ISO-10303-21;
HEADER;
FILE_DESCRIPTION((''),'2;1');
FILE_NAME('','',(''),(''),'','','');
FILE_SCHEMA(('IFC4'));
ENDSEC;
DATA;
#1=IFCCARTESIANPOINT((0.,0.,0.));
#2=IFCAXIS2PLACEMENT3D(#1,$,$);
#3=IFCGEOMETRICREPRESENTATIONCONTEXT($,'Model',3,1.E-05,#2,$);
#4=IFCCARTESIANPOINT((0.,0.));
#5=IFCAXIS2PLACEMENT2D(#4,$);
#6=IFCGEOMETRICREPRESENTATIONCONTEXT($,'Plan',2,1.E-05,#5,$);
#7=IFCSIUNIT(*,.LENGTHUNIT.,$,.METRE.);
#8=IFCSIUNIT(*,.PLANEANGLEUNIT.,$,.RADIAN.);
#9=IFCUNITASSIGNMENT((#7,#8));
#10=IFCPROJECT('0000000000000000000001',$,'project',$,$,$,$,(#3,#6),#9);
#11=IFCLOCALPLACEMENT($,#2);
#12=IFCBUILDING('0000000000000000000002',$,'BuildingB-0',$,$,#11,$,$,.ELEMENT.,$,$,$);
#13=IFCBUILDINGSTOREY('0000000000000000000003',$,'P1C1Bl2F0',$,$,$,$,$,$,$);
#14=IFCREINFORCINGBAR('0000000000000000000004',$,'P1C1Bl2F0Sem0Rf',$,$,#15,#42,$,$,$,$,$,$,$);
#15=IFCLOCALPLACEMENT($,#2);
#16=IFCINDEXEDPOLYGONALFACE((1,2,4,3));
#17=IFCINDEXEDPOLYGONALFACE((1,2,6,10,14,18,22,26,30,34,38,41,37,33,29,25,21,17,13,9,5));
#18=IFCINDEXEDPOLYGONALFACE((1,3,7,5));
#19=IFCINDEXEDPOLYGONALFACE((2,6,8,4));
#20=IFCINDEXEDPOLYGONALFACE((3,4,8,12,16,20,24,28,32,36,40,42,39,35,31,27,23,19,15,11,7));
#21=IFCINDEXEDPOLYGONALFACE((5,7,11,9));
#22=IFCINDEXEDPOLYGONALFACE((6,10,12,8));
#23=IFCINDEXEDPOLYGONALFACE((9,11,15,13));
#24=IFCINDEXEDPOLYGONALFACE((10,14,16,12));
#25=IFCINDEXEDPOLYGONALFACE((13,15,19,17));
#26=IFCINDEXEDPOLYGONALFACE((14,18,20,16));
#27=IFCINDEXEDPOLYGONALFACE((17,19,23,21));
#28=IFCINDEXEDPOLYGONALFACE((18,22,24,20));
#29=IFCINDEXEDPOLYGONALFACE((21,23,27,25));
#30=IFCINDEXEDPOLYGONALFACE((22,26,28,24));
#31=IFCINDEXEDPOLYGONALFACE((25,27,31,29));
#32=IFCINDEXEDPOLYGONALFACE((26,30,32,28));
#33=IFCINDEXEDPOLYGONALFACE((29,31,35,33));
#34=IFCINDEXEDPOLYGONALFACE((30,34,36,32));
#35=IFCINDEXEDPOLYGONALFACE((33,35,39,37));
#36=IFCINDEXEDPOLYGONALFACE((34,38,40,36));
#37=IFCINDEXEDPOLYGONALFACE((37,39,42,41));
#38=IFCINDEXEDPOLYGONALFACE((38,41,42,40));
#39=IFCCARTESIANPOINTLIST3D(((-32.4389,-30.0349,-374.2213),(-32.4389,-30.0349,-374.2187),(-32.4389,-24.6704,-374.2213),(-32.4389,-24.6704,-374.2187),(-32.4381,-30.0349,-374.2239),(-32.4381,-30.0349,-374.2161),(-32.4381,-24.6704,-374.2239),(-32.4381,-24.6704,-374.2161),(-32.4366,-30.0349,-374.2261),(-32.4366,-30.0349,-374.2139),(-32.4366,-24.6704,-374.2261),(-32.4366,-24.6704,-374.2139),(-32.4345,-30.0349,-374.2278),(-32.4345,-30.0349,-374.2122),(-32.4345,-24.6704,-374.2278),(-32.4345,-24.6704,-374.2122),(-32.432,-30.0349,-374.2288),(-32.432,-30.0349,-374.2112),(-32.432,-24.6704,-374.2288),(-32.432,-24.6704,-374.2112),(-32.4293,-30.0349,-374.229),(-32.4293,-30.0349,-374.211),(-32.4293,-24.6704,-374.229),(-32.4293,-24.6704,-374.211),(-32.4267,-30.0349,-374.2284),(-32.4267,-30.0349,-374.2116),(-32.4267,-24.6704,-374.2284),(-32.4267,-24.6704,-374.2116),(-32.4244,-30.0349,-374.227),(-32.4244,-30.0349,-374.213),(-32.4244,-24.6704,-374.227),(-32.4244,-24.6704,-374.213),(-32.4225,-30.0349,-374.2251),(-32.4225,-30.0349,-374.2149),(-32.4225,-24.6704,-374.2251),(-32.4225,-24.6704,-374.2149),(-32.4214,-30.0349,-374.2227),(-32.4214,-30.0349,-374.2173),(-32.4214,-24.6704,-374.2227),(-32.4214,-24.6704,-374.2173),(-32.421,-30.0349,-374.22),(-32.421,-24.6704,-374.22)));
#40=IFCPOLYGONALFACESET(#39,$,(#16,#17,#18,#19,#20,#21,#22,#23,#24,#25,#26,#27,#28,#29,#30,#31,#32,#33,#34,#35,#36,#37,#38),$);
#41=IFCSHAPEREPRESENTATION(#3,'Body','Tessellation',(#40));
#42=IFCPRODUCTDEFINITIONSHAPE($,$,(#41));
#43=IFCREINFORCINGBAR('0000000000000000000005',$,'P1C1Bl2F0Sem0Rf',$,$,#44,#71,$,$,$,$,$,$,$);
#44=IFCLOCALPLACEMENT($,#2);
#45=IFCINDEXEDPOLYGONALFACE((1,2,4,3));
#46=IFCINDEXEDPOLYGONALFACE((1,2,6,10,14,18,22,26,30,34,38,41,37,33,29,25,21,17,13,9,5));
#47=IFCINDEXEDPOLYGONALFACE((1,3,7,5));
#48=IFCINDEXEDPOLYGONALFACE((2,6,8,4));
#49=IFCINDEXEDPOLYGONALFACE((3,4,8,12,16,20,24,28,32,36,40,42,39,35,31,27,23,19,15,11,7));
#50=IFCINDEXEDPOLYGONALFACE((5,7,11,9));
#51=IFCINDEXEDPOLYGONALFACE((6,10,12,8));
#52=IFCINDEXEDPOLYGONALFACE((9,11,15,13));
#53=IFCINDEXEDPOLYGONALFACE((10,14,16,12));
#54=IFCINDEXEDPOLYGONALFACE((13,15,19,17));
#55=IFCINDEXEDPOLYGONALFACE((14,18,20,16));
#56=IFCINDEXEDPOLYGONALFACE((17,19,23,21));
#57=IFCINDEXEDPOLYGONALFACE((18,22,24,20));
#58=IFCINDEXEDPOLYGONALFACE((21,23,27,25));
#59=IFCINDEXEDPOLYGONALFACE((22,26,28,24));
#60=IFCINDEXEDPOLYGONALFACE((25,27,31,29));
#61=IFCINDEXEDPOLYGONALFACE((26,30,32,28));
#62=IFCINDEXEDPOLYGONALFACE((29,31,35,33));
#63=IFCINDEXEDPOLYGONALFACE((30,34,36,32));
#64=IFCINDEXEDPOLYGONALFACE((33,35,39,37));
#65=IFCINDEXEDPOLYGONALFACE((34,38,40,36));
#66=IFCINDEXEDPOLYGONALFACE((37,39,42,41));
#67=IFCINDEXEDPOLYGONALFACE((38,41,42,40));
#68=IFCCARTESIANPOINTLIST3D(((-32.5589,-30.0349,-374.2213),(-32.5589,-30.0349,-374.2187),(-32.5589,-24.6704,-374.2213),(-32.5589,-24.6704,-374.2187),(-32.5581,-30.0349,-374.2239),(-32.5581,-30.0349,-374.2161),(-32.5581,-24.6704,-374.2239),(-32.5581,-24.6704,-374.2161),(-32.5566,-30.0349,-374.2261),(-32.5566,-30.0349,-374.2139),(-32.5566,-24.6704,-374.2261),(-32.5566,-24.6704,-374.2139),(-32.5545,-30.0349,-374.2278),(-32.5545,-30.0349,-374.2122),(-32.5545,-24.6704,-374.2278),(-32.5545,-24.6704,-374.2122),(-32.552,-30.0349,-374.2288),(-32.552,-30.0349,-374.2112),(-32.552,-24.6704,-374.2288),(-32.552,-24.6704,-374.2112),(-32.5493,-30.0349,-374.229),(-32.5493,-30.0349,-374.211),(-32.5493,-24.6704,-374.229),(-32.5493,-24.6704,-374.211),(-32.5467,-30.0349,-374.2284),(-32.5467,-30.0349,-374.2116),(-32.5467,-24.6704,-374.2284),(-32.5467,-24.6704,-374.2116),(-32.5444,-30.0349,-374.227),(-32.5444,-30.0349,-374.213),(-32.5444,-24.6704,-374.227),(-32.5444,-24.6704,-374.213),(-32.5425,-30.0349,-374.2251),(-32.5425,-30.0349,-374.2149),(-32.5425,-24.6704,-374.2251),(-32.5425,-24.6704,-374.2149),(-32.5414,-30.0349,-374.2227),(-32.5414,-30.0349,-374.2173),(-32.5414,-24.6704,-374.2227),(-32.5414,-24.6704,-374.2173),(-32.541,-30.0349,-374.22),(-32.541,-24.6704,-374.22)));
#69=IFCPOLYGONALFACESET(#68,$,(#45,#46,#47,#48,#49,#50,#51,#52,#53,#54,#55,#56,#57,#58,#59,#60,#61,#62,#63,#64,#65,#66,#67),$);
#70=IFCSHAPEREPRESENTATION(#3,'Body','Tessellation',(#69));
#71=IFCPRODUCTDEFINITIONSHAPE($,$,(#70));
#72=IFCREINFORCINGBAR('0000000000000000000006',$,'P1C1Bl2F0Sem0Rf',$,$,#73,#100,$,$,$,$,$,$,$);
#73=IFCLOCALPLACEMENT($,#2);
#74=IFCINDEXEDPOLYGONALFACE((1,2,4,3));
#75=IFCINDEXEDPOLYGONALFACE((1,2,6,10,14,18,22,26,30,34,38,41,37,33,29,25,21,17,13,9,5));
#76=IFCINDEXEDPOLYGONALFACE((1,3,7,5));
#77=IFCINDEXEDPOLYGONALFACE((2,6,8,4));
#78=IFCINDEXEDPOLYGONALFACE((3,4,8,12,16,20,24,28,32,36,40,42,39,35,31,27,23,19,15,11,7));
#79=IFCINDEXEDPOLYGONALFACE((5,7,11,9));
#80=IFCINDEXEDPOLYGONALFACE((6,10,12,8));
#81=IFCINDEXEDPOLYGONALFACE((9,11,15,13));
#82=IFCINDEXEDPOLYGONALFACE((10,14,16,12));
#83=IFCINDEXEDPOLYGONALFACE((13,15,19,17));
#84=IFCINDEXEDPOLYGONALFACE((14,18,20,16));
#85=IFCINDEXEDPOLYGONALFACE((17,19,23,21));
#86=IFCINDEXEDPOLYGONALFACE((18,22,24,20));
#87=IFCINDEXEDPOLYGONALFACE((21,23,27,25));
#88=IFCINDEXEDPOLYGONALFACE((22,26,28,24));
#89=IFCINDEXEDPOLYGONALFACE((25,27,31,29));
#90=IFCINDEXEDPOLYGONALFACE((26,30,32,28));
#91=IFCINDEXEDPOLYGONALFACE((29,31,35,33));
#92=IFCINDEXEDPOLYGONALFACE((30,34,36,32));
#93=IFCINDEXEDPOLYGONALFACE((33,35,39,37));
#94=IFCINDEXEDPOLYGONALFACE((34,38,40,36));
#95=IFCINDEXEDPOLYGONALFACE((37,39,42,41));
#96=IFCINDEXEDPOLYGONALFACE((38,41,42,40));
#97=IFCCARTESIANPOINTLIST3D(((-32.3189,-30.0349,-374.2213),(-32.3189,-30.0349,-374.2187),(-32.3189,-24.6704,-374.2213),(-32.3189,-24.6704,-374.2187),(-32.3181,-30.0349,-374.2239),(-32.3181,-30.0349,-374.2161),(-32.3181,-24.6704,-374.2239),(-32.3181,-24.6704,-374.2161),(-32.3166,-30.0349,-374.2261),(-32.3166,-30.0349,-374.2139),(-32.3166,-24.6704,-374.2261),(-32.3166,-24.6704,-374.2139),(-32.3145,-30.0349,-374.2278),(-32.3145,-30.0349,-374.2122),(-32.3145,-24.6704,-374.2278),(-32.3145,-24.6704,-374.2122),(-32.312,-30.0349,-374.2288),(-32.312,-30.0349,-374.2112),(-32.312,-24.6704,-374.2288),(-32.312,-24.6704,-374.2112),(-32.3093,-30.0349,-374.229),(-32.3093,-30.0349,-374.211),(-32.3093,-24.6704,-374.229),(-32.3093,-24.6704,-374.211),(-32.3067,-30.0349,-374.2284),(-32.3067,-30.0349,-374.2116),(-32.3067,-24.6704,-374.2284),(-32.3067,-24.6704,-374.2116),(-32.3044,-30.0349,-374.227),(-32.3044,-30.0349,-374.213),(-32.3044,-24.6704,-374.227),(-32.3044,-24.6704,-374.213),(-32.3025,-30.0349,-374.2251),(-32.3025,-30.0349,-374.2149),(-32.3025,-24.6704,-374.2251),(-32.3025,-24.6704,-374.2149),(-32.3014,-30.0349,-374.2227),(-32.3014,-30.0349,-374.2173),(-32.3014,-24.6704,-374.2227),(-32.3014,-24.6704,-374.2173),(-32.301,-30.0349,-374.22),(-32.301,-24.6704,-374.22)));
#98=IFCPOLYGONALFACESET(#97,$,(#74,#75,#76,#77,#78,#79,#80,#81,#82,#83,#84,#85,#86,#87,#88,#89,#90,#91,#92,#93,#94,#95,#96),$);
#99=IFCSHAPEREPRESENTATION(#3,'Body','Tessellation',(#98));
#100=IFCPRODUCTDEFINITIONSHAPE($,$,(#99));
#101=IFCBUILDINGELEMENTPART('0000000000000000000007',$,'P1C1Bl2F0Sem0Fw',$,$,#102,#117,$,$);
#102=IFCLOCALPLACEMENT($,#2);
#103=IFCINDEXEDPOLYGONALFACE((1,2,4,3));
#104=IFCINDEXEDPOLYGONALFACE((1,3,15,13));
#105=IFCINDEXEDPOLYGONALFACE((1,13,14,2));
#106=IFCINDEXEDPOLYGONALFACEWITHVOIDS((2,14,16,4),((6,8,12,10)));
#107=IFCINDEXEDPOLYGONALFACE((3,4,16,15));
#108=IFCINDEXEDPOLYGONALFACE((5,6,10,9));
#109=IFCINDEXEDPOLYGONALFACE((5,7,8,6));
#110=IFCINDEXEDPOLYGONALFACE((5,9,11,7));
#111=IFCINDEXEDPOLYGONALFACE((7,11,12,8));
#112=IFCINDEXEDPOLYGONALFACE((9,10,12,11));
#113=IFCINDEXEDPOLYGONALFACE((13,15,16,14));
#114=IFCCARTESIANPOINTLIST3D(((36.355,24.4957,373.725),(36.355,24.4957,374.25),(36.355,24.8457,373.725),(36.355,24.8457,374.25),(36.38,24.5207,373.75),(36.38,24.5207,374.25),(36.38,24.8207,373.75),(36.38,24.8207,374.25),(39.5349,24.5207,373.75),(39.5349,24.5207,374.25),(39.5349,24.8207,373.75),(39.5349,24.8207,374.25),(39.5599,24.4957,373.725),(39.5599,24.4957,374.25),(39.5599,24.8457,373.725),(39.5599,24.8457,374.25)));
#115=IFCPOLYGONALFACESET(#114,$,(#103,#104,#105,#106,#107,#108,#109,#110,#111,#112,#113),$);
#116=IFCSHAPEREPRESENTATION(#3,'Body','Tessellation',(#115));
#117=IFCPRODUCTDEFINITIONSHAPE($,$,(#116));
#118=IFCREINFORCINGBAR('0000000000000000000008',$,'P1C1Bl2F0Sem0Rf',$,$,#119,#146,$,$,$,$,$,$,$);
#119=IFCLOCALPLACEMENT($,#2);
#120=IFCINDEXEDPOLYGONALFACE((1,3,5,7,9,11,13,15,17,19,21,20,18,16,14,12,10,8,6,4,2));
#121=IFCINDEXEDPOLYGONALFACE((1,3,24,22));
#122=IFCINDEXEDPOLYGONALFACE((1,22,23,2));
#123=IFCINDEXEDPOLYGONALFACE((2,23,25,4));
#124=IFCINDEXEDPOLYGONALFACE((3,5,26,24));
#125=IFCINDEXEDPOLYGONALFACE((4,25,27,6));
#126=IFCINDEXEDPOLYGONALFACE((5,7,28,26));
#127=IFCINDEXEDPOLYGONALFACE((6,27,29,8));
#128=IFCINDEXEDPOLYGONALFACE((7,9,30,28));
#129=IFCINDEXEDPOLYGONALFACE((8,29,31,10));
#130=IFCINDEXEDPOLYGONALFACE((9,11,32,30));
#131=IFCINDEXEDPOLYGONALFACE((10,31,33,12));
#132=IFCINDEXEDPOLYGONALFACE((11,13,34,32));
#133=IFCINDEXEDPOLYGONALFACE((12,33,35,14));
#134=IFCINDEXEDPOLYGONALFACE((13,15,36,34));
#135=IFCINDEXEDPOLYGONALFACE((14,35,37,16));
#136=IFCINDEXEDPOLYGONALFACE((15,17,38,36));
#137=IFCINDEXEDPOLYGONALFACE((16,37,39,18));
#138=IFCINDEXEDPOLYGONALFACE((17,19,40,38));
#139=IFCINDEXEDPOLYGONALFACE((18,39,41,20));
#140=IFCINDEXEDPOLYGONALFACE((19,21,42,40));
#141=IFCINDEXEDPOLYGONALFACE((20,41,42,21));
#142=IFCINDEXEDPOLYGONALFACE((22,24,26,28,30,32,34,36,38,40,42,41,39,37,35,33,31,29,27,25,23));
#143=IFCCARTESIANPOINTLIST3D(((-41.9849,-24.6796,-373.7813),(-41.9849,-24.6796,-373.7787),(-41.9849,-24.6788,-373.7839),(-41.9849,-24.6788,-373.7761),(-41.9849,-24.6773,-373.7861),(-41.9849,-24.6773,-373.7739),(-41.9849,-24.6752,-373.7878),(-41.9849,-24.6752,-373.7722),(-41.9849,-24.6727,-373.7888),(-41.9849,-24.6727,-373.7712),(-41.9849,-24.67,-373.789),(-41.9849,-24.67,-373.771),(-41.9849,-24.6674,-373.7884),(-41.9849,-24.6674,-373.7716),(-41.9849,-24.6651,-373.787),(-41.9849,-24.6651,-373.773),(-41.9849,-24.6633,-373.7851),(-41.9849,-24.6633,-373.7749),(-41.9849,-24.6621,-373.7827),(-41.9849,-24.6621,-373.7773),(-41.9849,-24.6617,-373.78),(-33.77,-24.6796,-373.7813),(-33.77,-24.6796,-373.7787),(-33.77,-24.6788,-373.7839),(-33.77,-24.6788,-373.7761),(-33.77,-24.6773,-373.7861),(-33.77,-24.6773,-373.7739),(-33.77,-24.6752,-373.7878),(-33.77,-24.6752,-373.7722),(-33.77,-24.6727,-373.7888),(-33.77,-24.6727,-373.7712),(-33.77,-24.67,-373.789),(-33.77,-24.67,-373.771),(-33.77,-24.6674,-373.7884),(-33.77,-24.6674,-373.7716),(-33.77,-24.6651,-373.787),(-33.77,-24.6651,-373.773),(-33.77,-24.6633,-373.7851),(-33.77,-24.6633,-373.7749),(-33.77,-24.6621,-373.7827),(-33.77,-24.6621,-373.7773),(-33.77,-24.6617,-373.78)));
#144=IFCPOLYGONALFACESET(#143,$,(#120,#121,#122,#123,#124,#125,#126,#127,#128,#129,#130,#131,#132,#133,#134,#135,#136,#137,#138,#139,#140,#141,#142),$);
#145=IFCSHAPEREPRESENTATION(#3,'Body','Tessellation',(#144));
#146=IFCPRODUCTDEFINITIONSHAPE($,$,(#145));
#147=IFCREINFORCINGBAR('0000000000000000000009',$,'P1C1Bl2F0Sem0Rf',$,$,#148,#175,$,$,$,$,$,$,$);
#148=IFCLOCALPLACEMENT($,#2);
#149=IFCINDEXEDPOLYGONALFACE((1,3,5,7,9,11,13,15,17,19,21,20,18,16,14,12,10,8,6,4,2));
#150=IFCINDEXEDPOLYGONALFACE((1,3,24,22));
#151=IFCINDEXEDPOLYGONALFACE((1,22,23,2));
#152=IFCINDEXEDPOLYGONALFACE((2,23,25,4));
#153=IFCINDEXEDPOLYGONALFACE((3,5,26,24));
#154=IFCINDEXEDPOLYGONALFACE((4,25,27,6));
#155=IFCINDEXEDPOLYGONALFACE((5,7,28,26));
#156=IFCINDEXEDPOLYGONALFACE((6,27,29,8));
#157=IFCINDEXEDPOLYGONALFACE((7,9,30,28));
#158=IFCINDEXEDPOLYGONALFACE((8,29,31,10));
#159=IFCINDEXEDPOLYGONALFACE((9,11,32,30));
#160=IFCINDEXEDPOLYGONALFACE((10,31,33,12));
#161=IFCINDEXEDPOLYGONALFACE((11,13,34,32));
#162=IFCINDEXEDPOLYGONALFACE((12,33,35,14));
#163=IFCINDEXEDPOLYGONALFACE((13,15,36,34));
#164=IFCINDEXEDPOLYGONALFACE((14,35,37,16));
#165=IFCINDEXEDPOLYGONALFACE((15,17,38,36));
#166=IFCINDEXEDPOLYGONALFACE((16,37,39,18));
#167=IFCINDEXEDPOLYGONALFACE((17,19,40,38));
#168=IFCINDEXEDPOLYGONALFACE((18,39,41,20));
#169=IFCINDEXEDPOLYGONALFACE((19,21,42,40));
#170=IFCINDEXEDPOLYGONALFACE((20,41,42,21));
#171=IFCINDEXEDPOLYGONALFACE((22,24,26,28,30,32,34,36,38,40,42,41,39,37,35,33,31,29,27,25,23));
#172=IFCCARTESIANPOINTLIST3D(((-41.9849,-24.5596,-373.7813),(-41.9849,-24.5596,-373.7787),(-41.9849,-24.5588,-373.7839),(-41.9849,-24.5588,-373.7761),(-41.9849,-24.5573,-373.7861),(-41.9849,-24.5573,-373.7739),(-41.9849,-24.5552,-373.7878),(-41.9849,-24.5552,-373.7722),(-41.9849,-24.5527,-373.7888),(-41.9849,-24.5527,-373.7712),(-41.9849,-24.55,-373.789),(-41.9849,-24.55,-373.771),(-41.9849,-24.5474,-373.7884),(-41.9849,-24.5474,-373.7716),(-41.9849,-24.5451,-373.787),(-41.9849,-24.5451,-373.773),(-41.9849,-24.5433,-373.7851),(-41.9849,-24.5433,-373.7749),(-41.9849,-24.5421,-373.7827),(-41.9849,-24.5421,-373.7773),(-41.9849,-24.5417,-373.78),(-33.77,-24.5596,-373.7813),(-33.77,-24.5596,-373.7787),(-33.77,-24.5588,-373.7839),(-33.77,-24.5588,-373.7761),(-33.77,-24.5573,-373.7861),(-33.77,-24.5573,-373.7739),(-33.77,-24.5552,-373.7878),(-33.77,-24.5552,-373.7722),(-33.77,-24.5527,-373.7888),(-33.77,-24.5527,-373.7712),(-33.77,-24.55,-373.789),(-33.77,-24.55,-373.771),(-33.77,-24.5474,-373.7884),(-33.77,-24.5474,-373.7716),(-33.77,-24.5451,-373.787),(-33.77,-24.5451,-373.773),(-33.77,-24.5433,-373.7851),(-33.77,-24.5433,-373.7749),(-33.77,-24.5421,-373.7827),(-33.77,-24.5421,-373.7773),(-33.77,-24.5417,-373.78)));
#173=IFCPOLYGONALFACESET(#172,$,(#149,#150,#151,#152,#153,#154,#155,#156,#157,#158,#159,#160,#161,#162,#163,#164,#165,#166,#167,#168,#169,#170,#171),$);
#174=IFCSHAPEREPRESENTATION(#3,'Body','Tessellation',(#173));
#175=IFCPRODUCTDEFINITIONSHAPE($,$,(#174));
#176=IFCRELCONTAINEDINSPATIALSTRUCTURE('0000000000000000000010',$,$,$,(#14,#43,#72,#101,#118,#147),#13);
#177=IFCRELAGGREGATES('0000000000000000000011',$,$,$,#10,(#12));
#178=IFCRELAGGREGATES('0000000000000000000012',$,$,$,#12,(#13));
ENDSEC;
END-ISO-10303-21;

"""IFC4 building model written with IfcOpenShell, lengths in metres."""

from ifc_helpers import new_model, entity, si_unit, origin, origin_2d, place, context, project, spatial, polyline, outline, extrude, element, save


model = new_model("IFC4")

# Units and contexts
model_context = context("Model", 3, precision=1e-05, world=origin())
plan_context = context("Plan", 2, precision=1e-05, world=origin_2d())
ifc_project = project(units=[si_unit("LENGTHUNIT", "METRE"), si_unit("PLANEANGLEUNIT", "RADIAN")], contexts=[model_context, plan_context])

# Building, storey
building_placement = place(None, origin())
building = spatial("IfcBuilding", under=ifc_project, at=building_placement, Name="BuildingB-0", CompositionType="ELEMENT")
storey = spatial("IfcBuildingStorey", under=building, Name="P1C1Bl2F0")

# Reinforcing bars
element("IfcReinforcingBar", 1, inside=storey, Name="P1C1Bl2F0Sem0Rf", context=model_context, shape_type="SweptSolid", body=[
    entity("IfcSurfaceCurveSweptAreaSolid", entity("IfcCircleProfileDef", "AREA", None, None, 0.009), None, entity("IfcPolyline", [entity("IfcCartesianPoint", [32.43, 24.6704, 374.22]), entity("IfcCartesianPoint", [32.43, 30.0349, 374.22])]), None, None, entity("IfcPlane", entity("IfcAxis2Placement3D", entity("IfcCartesianPoint", [32.43, 24.6704, 374.22]), entity("IfcDirection", [0.0, 0.0, 1.0]), entity("IfcDirection", [1.0, 0.0, 0.0])))),
])
element("IfcReinforcingBar", 2, inside=storey, Name="P1C1Bl2F0Sem0Rf", context=model_context, shape_type="SweptSolid", body=[
    entity("IfcSurfaceCurveSweptAreaSolid", entity("IfcCircleProfileDef", "AREA", None, None, 0.009), None, entity("IfcPolyline", [entity("IfcCartesianPoint", [32.55, 24.6704, 374.22]), entity("IfcCartesianPoint", [32.55, 30.0349, 374.22])]), None, None, entity("IfcPlane", entity("IfcAxis2Placement3D", entity("IfcCartesianPoint", [32.55, 24.6704, 374.22]), entity("IfcDirection", [0.0, 0.0, 1.0]), entity("IfcDirection", [1.0, 0.0, 0.0])))),
])
element("IfcReinforcingBar", 3, inside=storey, Name="P1C1Bl2F0Sem0Rf", context=model_context, shape_type="SweptSolid", body=[
    entity("IfcSurfaceCurveSweptAreaSolid", entity("IfcCircleProfileDef", "AREA", None, None, 0.009), None, entity("IfcPolyline", [entity("IfcCartesianPoint", [32.31, 24.6704, 374.22]), entity("IfcCartesianPoint", [32.31, 30.0349, 374.22])]), None, None, entity("IfcPlane", entity("IfcAxis2Placement3D", entity("IfcCartesianPoint", [32.31, 24.6704, 374.22]), entity("IfcDirection", [0.0, 0.0, 1.0]), entity("IfcDirection", [1.0, 0.0, 0.0])))),
])

# Building element part, opening
building_element_part_1 = element("IfcBuildingElementPart", 4, inside=storey, Name="P1C1Bl2F0Sem0Fw", context=model_context, shape_type="SweptSolid", body=[
    extrude(outline(polyline([(36.355, 24.4957, 373.725), (36.355, 24.8457, 373.725), (39.5599, 24.8457, 373.725), (39.5599, 24.4957, 373.725), (36.355, 24.4957, 373.725)])), None, (0.0, 0.0, 1.0), 0.525),
])
element("IfcOpeningElement", 5, inside=storey, cuts=building_element_part_1, context=model_context, shape_type="SweptSolid", body=[
    extrude(outline(polyline([(36.38, 24.5207, 373.75), (36.38, 24.8207, 373.75), (39.5349, 24.8207, 373.75), (39.5349, 24.5207, 373.75), (36.38, 24.5207, 373.75)])), None, (0.0, 0.0, 1.0), 0.5),
])

# Reinforcing bars
element("IfcReinforcingBar", 6, inside=storey, Name="P1C1Bl2F0Sem0Rf", context=model_context, shape_type="SweptSolid", body=[
    entity("IfcSurfaceCurveSweptAreaSolid", entity("IfcCircleProfileDef", "AREA", None, None, 0.009), None, entity("IfcPolyline", [entity("IfcCartesianPoint", [33.77, 24.6707, 373.78]), entity("IfcCartesianPoint", [41.9849, 24.6707, 373.78])]), None, None, entity("IfcPlane", entity("IfcAxis2Placement3D", entity("IfcCartesianPoint", [33.77, 24.6707, 373.78]), entity("IfcDirection", [0.0, 0.0, 1.0]), entity("IfcDirection", [1.0, 0.0, 0.0])))),
])
element("IfcReinforcingBar", 7, inside=storey, Name="P1C1Bl2F0Sem0Rf", context=model_context, shape_type="SweptSolid", body=[
    entity("IfcSurfaceCurveSweptAreaSolid", entity("IfcCircleProfileDef", "AREA", None, None, 0.009), None, entity("IfcPolyline", [entity("IfcCartesianPoint", [33.77, 24.5507, 373.78]), entity("IfcCartesianPoint", [41.9849, 24.5507, 373.78])]), None, None, entity("IfcPlane", entity("IfcAxis2Placement3D", entity("IfcCartesianPoint", [33.77, 24.5507, 373.78]), entity("IfcDirection", [0.0, 0.0, 1.0]), entity("IfcDirection", [1.0, 0.0, 0.0])))),
])

save(model, "model.ifc")
